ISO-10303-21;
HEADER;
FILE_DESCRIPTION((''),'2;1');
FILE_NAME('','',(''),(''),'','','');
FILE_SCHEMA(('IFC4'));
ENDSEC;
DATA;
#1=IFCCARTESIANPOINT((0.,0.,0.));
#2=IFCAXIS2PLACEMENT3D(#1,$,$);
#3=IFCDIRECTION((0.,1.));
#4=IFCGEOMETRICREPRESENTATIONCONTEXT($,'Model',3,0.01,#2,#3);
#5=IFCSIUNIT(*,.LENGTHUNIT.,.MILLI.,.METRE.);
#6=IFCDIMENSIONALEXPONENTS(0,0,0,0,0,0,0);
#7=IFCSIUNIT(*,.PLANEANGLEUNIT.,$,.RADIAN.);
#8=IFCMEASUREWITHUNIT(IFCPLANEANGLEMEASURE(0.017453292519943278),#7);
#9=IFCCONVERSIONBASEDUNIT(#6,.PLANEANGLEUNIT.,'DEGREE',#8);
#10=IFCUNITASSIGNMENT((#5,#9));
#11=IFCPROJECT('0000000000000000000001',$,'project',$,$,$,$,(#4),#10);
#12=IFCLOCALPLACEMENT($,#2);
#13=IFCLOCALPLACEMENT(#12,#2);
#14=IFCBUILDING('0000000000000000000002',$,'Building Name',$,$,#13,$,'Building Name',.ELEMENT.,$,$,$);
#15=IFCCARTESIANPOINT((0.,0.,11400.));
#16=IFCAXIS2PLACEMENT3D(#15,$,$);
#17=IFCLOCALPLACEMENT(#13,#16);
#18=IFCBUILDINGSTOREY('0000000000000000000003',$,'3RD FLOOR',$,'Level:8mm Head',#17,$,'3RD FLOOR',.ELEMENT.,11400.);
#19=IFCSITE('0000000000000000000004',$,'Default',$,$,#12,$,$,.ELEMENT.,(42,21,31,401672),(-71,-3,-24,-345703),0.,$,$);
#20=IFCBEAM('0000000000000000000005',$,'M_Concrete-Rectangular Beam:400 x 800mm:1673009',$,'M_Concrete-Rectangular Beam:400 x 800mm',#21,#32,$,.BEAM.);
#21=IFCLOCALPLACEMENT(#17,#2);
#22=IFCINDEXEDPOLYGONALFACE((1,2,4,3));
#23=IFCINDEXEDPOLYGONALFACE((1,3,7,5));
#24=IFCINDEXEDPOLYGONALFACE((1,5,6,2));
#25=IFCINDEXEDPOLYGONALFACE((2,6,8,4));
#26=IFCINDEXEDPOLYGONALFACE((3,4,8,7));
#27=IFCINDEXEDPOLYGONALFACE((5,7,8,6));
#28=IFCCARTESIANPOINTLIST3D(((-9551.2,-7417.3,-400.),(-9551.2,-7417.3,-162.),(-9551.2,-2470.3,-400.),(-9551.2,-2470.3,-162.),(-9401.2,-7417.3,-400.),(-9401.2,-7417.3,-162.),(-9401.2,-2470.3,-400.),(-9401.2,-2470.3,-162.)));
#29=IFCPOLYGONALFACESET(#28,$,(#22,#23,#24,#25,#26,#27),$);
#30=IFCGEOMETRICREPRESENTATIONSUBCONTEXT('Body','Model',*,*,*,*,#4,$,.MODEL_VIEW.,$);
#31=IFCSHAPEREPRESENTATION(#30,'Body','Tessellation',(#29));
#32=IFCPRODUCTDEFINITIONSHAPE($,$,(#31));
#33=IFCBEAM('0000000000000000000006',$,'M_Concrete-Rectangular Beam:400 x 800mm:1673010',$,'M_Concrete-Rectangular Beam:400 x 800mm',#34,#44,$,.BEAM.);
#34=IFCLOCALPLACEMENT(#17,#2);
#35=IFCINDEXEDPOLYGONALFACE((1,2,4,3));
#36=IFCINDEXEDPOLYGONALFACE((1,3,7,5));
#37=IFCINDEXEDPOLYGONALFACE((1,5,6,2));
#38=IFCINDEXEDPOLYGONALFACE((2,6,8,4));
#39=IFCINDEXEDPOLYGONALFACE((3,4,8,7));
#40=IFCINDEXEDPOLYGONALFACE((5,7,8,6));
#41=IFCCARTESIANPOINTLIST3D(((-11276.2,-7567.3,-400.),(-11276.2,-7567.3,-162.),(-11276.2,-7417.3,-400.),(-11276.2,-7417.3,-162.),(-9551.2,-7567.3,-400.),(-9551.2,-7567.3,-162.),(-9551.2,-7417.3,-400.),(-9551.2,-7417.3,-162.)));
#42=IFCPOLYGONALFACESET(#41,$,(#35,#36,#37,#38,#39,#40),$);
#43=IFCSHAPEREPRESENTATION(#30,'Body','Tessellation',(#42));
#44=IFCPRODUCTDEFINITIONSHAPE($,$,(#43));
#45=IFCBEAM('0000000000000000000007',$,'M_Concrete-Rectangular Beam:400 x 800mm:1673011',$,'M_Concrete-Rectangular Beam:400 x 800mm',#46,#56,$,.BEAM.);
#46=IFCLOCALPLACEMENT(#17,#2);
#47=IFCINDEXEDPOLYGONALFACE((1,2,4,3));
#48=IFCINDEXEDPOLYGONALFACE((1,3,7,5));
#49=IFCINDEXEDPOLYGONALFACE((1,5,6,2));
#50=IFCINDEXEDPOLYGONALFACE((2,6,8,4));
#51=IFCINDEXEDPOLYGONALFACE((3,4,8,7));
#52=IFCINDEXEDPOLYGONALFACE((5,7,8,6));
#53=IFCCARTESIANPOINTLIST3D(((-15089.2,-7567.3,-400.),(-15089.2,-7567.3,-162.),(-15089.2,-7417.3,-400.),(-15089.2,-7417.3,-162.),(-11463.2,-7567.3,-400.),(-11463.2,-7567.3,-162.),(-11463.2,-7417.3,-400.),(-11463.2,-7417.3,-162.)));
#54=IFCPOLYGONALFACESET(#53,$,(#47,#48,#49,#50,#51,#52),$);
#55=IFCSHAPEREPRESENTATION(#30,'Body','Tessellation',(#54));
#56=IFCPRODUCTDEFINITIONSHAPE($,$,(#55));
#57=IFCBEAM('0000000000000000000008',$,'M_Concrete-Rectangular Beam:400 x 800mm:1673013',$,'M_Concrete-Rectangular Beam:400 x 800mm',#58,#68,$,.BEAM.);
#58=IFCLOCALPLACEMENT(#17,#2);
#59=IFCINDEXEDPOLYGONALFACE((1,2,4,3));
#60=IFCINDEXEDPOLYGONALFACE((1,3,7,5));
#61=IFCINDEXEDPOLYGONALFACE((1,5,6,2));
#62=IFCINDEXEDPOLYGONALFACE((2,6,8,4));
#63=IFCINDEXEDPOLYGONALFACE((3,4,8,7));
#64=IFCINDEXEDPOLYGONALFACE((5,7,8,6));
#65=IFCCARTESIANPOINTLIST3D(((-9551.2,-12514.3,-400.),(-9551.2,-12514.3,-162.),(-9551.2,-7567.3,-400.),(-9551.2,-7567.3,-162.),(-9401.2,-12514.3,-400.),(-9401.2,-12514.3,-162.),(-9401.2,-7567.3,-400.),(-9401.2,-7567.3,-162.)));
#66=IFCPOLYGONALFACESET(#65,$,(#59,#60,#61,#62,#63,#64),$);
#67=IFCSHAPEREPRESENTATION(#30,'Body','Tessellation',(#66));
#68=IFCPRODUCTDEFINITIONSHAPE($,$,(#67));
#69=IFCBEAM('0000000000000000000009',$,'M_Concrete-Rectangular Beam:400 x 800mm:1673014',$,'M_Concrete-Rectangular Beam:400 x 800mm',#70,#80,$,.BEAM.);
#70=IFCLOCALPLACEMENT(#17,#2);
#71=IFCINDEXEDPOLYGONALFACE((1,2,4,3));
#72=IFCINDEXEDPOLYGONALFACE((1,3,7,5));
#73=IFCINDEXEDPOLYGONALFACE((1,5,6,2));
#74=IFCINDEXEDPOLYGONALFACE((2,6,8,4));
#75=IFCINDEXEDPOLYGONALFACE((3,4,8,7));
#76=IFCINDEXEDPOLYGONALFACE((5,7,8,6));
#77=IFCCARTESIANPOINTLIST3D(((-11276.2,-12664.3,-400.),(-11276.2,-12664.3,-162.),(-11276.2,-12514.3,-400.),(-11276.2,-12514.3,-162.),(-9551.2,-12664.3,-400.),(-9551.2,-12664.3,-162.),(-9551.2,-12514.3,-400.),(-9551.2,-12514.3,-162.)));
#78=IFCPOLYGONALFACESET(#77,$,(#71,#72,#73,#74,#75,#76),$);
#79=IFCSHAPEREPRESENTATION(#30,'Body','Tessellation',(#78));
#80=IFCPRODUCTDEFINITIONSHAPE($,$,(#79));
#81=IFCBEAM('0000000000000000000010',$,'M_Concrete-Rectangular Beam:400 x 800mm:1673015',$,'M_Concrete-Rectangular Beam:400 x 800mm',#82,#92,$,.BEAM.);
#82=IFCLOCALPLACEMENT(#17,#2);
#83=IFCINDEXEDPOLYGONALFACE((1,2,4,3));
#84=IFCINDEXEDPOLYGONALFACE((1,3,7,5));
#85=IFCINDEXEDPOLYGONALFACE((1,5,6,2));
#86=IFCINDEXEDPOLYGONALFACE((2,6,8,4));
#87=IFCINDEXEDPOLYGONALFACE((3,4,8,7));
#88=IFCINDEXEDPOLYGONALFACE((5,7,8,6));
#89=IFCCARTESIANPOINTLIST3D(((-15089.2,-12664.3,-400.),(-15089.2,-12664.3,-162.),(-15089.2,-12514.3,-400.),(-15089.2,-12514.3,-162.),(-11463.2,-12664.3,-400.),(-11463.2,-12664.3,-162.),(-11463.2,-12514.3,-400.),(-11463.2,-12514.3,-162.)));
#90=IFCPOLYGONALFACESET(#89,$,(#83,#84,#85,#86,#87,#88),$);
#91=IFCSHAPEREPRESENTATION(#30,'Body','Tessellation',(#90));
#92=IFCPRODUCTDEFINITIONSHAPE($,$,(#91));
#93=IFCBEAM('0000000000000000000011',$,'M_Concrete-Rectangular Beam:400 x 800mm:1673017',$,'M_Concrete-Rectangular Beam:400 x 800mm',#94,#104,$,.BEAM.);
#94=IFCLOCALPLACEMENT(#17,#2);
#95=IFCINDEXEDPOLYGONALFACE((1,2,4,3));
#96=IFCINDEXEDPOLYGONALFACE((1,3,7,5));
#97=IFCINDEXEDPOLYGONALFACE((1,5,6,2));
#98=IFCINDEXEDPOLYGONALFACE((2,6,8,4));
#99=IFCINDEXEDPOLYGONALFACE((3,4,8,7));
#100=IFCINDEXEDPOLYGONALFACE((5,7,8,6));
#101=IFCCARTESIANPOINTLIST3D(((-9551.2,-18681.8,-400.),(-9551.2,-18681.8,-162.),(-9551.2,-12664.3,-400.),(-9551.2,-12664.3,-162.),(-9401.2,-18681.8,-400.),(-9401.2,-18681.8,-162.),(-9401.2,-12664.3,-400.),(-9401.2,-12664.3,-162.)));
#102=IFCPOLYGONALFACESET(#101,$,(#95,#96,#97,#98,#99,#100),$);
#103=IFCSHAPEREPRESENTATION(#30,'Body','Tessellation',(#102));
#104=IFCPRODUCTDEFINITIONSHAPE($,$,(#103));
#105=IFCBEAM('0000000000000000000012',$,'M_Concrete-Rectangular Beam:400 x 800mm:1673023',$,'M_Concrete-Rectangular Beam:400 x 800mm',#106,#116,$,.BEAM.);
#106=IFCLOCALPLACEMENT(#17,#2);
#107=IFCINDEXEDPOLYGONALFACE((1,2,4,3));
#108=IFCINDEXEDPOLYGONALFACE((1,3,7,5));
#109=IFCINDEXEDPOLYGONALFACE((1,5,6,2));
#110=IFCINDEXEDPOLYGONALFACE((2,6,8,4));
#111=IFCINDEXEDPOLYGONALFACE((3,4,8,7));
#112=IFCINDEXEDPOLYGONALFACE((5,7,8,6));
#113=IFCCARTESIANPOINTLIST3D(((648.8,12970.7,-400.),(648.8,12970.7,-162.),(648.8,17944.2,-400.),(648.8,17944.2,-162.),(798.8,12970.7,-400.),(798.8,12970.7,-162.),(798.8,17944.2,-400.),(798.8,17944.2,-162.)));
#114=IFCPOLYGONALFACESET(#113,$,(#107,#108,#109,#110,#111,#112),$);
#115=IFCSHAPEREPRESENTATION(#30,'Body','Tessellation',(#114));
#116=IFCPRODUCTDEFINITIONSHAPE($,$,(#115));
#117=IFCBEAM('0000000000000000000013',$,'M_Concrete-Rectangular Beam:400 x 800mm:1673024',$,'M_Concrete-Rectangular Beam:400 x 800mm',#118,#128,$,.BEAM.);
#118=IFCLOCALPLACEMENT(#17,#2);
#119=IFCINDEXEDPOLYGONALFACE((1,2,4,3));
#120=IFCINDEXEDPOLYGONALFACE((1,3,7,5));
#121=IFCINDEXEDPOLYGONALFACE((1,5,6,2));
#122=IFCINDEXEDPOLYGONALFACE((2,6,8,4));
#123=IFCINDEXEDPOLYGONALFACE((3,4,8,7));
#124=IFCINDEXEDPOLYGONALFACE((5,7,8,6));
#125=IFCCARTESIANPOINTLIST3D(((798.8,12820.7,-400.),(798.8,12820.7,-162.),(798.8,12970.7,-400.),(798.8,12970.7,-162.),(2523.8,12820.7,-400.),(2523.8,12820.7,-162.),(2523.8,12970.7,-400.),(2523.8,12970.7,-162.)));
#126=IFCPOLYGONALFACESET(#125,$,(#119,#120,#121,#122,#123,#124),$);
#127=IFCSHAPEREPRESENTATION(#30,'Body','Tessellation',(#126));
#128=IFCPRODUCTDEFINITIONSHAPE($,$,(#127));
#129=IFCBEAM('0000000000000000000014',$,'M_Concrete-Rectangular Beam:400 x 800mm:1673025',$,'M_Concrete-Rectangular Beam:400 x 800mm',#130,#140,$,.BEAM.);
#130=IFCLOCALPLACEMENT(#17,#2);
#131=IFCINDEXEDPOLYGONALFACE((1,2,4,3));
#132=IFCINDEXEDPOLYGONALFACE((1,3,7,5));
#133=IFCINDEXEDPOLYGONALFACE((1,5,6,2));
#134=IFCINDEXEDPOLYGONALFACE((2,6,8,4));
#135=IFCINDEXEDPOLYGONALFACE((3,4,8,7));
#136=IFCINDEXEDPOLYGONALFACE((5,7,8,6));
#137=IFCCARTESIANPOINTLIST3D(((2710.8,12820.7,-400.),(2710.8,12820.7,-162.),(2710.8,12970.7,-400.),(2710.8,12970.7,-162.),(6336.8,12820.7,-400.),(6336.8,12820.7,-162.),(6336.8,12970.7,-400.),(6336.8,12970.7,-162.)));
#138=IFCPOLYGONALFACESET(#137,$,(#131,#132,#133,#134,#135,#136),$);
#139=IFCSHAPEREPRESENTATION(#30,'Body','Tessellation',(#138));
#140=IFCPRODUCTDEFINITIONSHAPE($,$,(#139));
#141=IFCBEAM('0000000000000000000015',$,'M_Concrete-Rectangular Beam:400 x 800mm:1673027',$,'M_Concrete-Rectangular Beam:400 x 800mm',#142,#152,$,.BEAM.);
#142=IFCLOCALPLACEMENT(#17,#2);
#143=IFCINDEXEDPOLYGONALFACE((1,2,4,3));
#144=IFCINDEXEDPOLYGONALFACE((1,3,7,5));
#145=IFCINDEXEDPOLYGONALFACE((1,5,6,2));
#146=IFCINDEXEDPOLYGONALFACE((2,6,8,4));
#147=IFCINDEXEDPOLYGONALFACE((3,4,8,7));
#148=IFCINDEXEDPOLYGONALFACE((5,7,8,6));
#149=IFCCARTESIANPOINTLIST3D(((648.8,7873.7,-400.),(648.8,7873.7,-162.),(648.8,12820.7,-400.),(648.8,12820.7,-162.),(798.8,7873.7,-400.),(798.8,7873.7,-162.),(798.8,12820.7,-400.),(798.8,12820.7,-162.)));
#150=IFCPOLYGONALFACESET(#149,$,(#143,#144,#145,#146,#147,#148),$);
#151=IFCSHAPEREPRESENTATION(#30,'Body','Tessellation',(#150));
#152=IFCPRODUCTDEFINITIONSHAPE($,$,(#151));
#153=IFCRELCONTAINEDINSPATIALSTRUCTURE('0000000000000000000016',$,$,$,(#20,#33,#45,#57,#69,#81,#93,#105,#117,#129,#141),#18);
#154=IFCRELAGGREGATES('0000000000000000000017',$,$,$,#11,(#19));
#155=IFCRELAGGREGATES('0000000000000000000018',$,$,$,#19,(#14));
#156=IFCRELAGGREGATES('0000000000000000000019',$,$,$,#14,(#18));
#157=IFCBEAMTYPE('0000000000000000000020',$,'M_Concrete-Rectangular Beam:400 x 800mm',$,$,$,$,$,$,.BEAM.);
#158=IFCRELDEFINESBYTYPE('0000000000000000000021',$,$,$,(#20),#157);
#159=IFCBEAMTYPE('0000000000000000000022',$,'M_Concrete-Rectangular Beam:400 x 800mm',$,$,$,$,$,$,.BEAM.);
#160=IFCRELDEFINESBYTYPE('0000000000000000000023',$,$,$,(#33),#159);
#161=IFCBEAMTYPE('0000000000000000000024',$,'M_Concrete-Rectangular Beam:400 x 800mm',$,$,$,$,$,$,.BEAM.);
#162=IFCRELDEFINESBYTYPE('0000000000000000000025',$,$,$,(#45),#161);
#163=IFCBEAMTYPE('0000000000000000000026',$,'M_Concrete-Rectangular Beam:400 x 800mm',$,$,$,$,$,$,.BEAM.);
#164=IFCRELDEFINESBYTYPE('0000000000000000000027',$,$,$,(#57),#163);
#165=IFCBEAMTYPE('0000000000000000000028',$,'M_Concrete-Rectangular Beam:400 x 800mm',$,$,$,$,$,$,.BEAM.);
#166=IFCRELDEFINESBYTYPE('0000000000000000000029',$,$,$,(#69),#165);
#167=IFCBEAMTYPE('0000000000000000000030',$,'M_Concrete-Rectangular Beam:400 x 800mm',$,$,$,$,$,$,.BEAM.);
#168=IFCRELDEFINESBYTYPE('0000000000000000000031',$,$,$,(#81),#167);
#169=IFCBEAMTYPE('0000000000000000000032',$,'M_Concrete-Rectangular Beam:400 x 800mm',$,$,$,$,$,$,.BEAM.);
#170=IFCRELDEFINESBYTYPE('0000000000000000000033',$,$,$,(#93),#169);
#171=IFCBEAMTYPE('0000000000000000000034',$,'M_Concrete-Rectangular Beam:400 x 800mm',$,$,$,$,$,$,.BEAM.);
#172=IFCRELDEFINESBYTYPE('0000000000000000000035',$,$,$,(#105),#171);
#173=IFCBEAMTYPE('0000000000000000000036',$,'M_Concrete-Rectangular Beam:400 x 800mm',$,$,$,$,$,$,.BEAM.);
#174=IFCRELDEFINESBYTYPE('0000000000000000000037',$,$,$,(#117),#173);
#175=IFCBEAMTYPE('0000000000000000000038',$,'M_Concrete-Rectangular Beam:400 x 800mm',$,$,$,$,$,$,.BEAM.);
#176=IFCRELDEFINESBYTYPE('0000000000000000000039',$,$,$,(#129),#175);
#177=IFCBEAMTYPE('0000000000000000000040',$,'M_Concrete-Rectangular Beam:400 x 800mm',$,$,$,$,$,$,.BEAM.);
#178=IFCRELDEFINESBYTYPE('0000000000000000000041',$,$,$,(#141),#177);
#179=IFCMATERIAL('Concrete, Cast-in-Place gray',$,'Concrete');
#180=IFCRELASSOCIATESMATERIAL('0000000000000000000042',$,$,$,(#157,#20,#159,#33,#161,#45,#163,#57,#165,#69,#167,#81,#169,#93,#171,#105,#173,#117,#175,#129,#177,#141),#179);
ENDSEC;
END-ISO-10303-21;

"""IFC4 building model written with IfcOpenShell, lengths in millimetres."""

from ifc_helpers import new_model, entity, si_unit, converted_unit, direction, frame, origin, place, context, subcontext, project, spatial, indexed_curve, outline, extrude, source, transform, mapped, material, type_object, type_shapes, element, save


model = new_model("IFC4")

# Units and contexts
model_context = context("Model", 3, precision=0.01, world=origin(), true_north=direction((0.0, 1.0)))
body_context = subcontext(model_context, "Body", "Model", "MODEL_VIEW")
ifc_project = project(units=[si_unit("LENGTHUNIT", "METRE", prefix="MILLI"), converted_unit("PLANEANGLEUNIT", "DEGREE", entity("IfcPlaneAngleMeasure", 0.017453292519943278), si_unit("PLANEANGLEUNIT", "RADIAN"), dimensions=[0, 0, 0, 0, 0, 0, 0])], contexts=[model_context])

# Site, building, storey
site_placement = place(None, origin())
site = spatial("IfcSite", under=ifc_project, at=site_placement, Name="Default", CompositionType="ELEMENT", RefLatitude=(42, 21, 31, 401672), RefLongitude=(-71, -3, -24, -345703), RefElevation=0.0)
building_placement = place(site_placement, origin())
building = spatial("IfcBuilding", under=site, at=building_placement, Name="Building Name", LongName="Building Name", CompositionType="ELEMENT")
storey_placement = place(building_placement, frame((0.0, 0.0, 11400.0)))
storey = spatial("IfcBuildingStorey", under=building, at=storey_placement, Name="3RD FLOOR", ObjectType="Level:8mm Head", LongName="3RD FLOOR", CompositionType="ELEMENT", Elevation=11400.0)

# Beams
ifc_material = material(Name="Concrete, Cast-in-Place gray", Category="Concrete")
beam_type_1 = type_object("IfcBeamType", Name="M_Concrete-Rectangular Beam:400 x 800mm", PredefinedType="BEAM", material=ifc_material)
shared_shape_1 = source(origin(), body_context, "Body", "SweptSolid", [
    extrude(outline(indexed_curve([(-75.0, -119.0), (75.0, -119.0), (75.0, 119.0), (-75.0, 119.0), (-75.0, -119.0)], self_intersect=False)), frame((-9476.2, -2470.3, 11119.0), z_axis=(0.0, -1.0, 0.0), x_axis=(-1.0, 0.0, 0.0)), (0.0, 0.0, 1.0), 4947.0),
])
type_shapes(beam_type_1, [shared_shape_1])
beam_1_placement = place(storey_placement, frame((0.0, 0.0, -11400.0)))
element("IfcBeam", 1, at=beam_1_placement, inside=storey, type_object=beam_type_1, material=ifc_material, Name="M_Concrete-Rectangular Beam:400 x 800mm:1673009", ObjectType="M_Concrete-Rectangular Beam:400 x 800mm", PredefinedType="BEAM", context=body_context, shape_type="MappedRepresentation", body=[
    mapped(shared_shape_1, transform((0.0, 0.0, 0.0), scale=1.0)),
])
beam_type_2 = type_object("IfcBeamType", Name="M_Concrete-Rectangular Beam:400 x 800mm", PredefinedType="BEAM", material=ifc_material)
shared_shape_2 = source(origin(), body_context, "Body", "SweptSolid", [
    extrude(outline(indexed_curve([(-119.0, -75.0), (119.0, -75.0), (119.0, 75.0), (-119.0, 75.0), (-119.0, -75.0)], self_intersect=False)), frame((-9551.2, -7492.3, 11119.0), z_axis=(-1.0, 0.0, 0.0), x_axis=(0.0, 0.0, -1.0)), (0.0, 0.0, 1.0), 1725.0),
])
type_shapes(beam_type_2, [shared_shape_2])
beam_2_placement = place(storey_placement, frame((0.0, 0.0, -11400.0)))
element("IfcBeam", 2, at=beam_2_placement, inside=storey, type_object=beam_type_2, material=ifc_material, Name="M_Concrete-Rectangular Beam:400 x 800mm:1673010", ObjectType="M_Concrete-Rectangular Beam:400 x 800mm", PredefinedType="BEAM", context=body_context, shape_type="MappedRepresentation", body=[
    mapped(shared_shape_2, transform((0.0, 0.0, 0.0), scale=1.0)),
])
beam_type_3 = type_object("IfcBeamType", Name="M_Concrete-Rectangular Beam:400 x 800mm", PredefinedType="BEAM", material=ifc_material)
shared_shape_3 = source(origin(), body_context, "Body", "SweptSolid", [
    extrude(outline(indexed_curve([(-119.0, -75.0), (119.0, -75.0), (119.0, 75.0), (-119.0, 75.0), (-119.0, -75.0)], self_intersect=False)), frame((-11463.2, -7492.3, 11119.0), z_axis=(-1.0, 0.0, 0.0), x_axis=(0.0, 0.0, -1.0)), (0.0, 0.0, 1.0), 3626.0),
])
type_shapes(beam_type_3, [shared_shape_3])
beam_3_placement = place(storey_placement, frame((0.0, 0.0, -11400.0)))
element("IfcBeam", 3, at=beam_3_placement, inside=storey, type_object=beam_type_3, material=ifc_material, Name="M_Concrete-Rectangular Beam:400 x 800mm:1673011", ObjectType="M_Concrete-Rectangular Beam:400 x 800mm", PredefinedType="BEAM", context=body_context, shape_type="MappedRepresentation", body=[
    mapped(shared_shape_3, transform((0.0, 0.0, 0.0), scale=1.0)),
])
beam_type_4 = type_object("IfcBeamType", Name="M_Concrete-Rectangular Beam:400 x 800mm", PredefinedType="BEAM", material=ifc_material)
shared_shape_4 = source(origin(), body_context, "Body", "SweptSolid", [
    extrude(outline(indexed_curve([(-75.0, -119.0), (75.0, -119.0), (75.0, 119.0), (-75.0, 119.0), (-75.0, -119.0)], self_intersect=False)), frame((-9476.2, -7567.3, 11119.0), z_axis=(0.0, -1.0, 0.0), x_axis=(-1.0, 0.0, 0.0)), (0.0, 0.0, 1.0), 4947.0),
])
type_shapes(beam_type_4, [shared_shape_4])
beam_4_placement = place(storey_placement, frame((0.0, 0.0, -11400.0)))
element("IfcBeam", 4, at=beam_4_placement, inside=storey, type_object=beam_type_4, material=ifc_material, Name="M_Concrete-Rectangular Beam:400 x 800mm:1673013", ObjectType="M_Concrete-Rectangular Beam:400 x 800mm", PredefinedType="BEAM", context=body_context, shape_type="MappedRepresentation", body=[
    mapped(shared_shape_4, transform((0.0, 0.0, 0.0), scale=1.0)),
])
beam_type_5 = type_object("IfcBeamType", Name="M_Concrete-Rectangular Beam:400 x 800mm", PredefinedType="BEAM", material=ifc_material)
shared_shape_5 = source(origin(), body_context, "Body", "SweptSolid", [
    extrude(outline(indexed_curve([(-119.0, -75.0), (119.0, -75.0), (119.0, 75.0), (-119.0, 75.0), (-119.0, -75.0)], self_intersect=False)), frame((-9551.2, -12589.3, 11119.0), z_axis=(-1.0, 0.0, 0.0), x_axis=(0.0, 0.0, -1.0)), (0.0, 0.0, 1.0), 1725.0),
])
type_shapes(beam_type_5, [shared_shape_5])
beam_5_placement = place(storey_placement, frame((0.0, 0.0, -11400.0)))
element("IfcBeam", 5, at=beam_5_placement, inside=storey, type_object=beam_type_5, material=ifc_material, Name="M_Concrete-Rectangular Beam:400 x 800mm:1673014", ObjectType="M_Concrete-Rectangular Beam:400 x 800mm", PredefinedType="BEAM", context=body_context, shape_type="MappedRepresentation", body=[
    mapped(shared_shape_5, transform((0.0, 0.0, 0.0), scale=1.0)),
])
beam_type_6 = type_object("IfcBeamType", Name="M_Concrete-Rectangular Beam:400 x 800mm", PredefinedType="BEAM", material=ifc_material)
shared_shape_6 = source(origin(), body_context, "Body", "SweptSolid", [
    extrude(outline(indexed_curve([(-119.0, -75.0), (119.0, -75.0), (119.0, 75.0), (-119.0, 75.0), (-119.0, -75.0)], self_intersect=False)), frame((-11463.2, -12589.3, 11119.0), z_axis=(-1.0, 0.0, 0.0), x_axis=(0.0, 0.0, -1.0)), (0.0, 0.0, 1.0), 3626.0),
])
type_shapes(beam_type_6, [shared_shape_6])
beam_6_placement = place(storey_placement, frame((0.0, 0.0, -11400.0)))
element("IfcBeam", 6, at=beam_6_placement, inside=storey, type_object=beam_type_6, material=ifc_material, Name="M_Concrete-Rectangular Beam:400 x 800mm:1673015", ObjectType="M_Concrete-Rectangular Beam:400 x 800mm", PredefinedType="BEAM", context=body_context, shape_type="MappedRepresentation", body=[
    mapped(shared_shape_6, transform((0.0, 0.0, 0.0), scale=1.0)),
])
beam_type_7 = type_object("IfcBeamType", Name="M_Concrete-Rectangular Beam:400 x 800mm", PredefinedType="BEAM", material=ifc_material)
shared_shape_7 = source(origin(), body_context, "Body", "SweptSolid", [
    extrude(outline(indexed_curve([(-75.0, -119.0), (75.0, -119.0), (75.0, 119.0), (-75.0, 119.0), (-75.0, -119.0)], self_intersect=False)), frame((-9476.2, -12664.3, 11119.0), z_axis=(0.0, -1.0, 0.0), x_axis=(-1.0, 0.0, 0.0)), (0.0, 0.0, 1.0), 6017.5),
])
type_shapes(beam_type_7, [shared_shape_7])
beam_7_placement = place(storey_placement, frame((0.0, 0.0, -11400.0)))
element("IfcBeam", 7, at=beam_7_placement, inside=storey, type_object=beam_type_7, material=ifc_material, Name="M_Concrete-Rectangular Beam:400 x 800mm:1673017", ObjectType="M_Concrete-Rectangular Beam:400 x 800mm", PredefinedType="BEAM", context=body_context, shape_type="MappedRepresentation", body=[
    mapped(shared_shape_7, transform((0.0, 0.0, 0.0), scale=1.0)),
])
beam_type_8 = type_object("IfcBeamType", Name="M_Concrete-Rectangular Beam:400 x 800mm", PredefinedType="BEAM", material=ifc_material)
shared_shape_8 = source(origin(), body_context, "Body", "SweptSolid", [
    extrude(outline(indexed_curve([(-75.0, -119.0), (75.0, -119.0), (75.0, 119.0), (-75.0, 119.0), (-75.0, -119.0)], self_intersect=False)), frame((723.8, 17944.2, 11119.0), z_axis=(0.0, -1.0, 0.0), x_axis=(-1.0, 0.0, 0.0)), (0.0, 0.0, 1.0), 4973.5),
])
type_shapes(beam_type_8, [shared_shape_8])
beam_8_placement = place(storey_placement, frame((0.0, 0.0, -11400.0)))
element("IfcBeam", 8, at=beam_8_placement, inside=storey, type_object=beam_type_8, material=ifc_material, Name="M_Concrete-Rectangular Beam:400 x 800mm:1673023", ObjectType="M_Concrete-Rectangular Beam:400 x 800mm", PredefinedType="BEAM", context=body_context, shape_type="MappedRepresentation", body=[
    mapped(shared_shape_8, transform((0.0, 0.0, 0.0), scale=1.0)),
])
beam_type_9 = type_object("IfcBeamType", Name="M_Concrete-Rectangular Beam:400 x 800mm", PredefinedType="BEAM", material=ifc_material)
shared_shape_9 = source(origin(), body_context, "Body", "SweptSolid", [
    extrude(outline(indexed_curve([(-119.0, -75.0), (119.0, -75.0), (119.0, 75.0), (-119.0, 75.0), (-119.0, -75.0)], self_intersect=False)), frame((798.8, 12895.7, 11119.0), z_axis=(1.0, 0.0, 0.0), x_axis=(0.0, 0.0, -1.0)), (0.0, 0.0, 1.0), 1725.0),
])
type_shapes(beam_type_9, [shared_shape_9])
beam_9_placement = place(storey_placement, frame((0.0, 0.0, -11400.0)))
element("IfcBeam", 9, at=beam_9_placement, inside=storey, type_object=beam_type_9, material=ifc_material, Name="M_Concrete-Rectangular Beam:400 x 800mm:1673024", ObjectType="M_Concrete-Rectangular Beam:400 x 800mm", PredefinedType="BEAM", context=body_context, shape_type="MappedRepresentation", body=[
    mapped(shared_shape_9, transform((0.0, 0.0, 0.0), scale=1.0)),
])
beam_type_10 = type_object("IfcBeamType", Name="M_Concrete-Rectangular Beam:400 x 800mm", PredefinedType="BEAM", material=ifc_material)
shared_shape_10 = source(origin(), body_context, "Body", "SweptSolid", [
    extrude(outline(indexed_curve([(-119.0, -75.0), (119.0, -75.0), (119.0, 75.0), (-119.0, 75.0), (-119.0, -75.0)], self_intersect=False)), frame((2710.8, 12895.7, 11119.0), z_axis=(1.0, 0.0, 0.0), x_axis=(0.0, 0.0, -1.0)), (0.0, 0.0, 1.0), 3626.0),
])
type_shapes(beam_type_10, [shared_shape_10])
beam_10_placement = place(storey_placement, frame((0.0, 0.0, -11400.0)))
element("IfcBeam", 10, at=beam_10_placement, inside=storey, type_object=beam_type_10, material=ifc_material, Name="M_Concrete-Rectangular Beam:400 x 800mm:1673025", ObjectType="M_Concrete-Rectangular Beam:400 x 800mm", PredefinedType="BEAM", context=body_context, shape_type="MappedRepresentation", body=[
    mapped(shared_shape_10, transform((0.0, 0.0, 0.0), scale=1.0)),
])
beam_type_11 = type_object("IfcBeamType", Name="M_Concrete-Rectangular Beam:400 x 800mm", PredefinedType="BEAM", material=ifc_material)
shared_shape_11 = source(origin(), body_context, "Body", "SweptSolid", [
    extrude(outline(indexed_curve([(-75.0, -119.0), (75.0, -119.0), (75.0, 119.0), (-75.0, 119.0), (-75.0, -119.0)], self_intersect=False)), frame((723.8, 12820.7, 11119.0), z_axis=(0.0, -1.0, 0.0), x_axis=(-1.0, 0.0, 0.0)), (0.0, 0.0, 1.0), 4947.0),
])
type_shapes(beam_type_11, [shared_shape_11])
beam_11_placement = place(storey_placement, frame((0.0, 0.0, -11400.0)))
element("IfcBeam", 11, at=beam_11_placement, inside=storey, type_object=beam_type_11, material=ifc_material, Name="M_Concrete-Rectangular Beam:400 x 800mm:1673027", ObjectType="M_Concrete-Rectangular Beam:400 x 800mm", PredefinedType="BEAM", context=body_context, shape_type="MappedRepresentation", body=[
    mapped(shared_shape_11, transform((0.0, 0.0, 0.0), scale=1.0)),
])

save(model, "model.ifc")
